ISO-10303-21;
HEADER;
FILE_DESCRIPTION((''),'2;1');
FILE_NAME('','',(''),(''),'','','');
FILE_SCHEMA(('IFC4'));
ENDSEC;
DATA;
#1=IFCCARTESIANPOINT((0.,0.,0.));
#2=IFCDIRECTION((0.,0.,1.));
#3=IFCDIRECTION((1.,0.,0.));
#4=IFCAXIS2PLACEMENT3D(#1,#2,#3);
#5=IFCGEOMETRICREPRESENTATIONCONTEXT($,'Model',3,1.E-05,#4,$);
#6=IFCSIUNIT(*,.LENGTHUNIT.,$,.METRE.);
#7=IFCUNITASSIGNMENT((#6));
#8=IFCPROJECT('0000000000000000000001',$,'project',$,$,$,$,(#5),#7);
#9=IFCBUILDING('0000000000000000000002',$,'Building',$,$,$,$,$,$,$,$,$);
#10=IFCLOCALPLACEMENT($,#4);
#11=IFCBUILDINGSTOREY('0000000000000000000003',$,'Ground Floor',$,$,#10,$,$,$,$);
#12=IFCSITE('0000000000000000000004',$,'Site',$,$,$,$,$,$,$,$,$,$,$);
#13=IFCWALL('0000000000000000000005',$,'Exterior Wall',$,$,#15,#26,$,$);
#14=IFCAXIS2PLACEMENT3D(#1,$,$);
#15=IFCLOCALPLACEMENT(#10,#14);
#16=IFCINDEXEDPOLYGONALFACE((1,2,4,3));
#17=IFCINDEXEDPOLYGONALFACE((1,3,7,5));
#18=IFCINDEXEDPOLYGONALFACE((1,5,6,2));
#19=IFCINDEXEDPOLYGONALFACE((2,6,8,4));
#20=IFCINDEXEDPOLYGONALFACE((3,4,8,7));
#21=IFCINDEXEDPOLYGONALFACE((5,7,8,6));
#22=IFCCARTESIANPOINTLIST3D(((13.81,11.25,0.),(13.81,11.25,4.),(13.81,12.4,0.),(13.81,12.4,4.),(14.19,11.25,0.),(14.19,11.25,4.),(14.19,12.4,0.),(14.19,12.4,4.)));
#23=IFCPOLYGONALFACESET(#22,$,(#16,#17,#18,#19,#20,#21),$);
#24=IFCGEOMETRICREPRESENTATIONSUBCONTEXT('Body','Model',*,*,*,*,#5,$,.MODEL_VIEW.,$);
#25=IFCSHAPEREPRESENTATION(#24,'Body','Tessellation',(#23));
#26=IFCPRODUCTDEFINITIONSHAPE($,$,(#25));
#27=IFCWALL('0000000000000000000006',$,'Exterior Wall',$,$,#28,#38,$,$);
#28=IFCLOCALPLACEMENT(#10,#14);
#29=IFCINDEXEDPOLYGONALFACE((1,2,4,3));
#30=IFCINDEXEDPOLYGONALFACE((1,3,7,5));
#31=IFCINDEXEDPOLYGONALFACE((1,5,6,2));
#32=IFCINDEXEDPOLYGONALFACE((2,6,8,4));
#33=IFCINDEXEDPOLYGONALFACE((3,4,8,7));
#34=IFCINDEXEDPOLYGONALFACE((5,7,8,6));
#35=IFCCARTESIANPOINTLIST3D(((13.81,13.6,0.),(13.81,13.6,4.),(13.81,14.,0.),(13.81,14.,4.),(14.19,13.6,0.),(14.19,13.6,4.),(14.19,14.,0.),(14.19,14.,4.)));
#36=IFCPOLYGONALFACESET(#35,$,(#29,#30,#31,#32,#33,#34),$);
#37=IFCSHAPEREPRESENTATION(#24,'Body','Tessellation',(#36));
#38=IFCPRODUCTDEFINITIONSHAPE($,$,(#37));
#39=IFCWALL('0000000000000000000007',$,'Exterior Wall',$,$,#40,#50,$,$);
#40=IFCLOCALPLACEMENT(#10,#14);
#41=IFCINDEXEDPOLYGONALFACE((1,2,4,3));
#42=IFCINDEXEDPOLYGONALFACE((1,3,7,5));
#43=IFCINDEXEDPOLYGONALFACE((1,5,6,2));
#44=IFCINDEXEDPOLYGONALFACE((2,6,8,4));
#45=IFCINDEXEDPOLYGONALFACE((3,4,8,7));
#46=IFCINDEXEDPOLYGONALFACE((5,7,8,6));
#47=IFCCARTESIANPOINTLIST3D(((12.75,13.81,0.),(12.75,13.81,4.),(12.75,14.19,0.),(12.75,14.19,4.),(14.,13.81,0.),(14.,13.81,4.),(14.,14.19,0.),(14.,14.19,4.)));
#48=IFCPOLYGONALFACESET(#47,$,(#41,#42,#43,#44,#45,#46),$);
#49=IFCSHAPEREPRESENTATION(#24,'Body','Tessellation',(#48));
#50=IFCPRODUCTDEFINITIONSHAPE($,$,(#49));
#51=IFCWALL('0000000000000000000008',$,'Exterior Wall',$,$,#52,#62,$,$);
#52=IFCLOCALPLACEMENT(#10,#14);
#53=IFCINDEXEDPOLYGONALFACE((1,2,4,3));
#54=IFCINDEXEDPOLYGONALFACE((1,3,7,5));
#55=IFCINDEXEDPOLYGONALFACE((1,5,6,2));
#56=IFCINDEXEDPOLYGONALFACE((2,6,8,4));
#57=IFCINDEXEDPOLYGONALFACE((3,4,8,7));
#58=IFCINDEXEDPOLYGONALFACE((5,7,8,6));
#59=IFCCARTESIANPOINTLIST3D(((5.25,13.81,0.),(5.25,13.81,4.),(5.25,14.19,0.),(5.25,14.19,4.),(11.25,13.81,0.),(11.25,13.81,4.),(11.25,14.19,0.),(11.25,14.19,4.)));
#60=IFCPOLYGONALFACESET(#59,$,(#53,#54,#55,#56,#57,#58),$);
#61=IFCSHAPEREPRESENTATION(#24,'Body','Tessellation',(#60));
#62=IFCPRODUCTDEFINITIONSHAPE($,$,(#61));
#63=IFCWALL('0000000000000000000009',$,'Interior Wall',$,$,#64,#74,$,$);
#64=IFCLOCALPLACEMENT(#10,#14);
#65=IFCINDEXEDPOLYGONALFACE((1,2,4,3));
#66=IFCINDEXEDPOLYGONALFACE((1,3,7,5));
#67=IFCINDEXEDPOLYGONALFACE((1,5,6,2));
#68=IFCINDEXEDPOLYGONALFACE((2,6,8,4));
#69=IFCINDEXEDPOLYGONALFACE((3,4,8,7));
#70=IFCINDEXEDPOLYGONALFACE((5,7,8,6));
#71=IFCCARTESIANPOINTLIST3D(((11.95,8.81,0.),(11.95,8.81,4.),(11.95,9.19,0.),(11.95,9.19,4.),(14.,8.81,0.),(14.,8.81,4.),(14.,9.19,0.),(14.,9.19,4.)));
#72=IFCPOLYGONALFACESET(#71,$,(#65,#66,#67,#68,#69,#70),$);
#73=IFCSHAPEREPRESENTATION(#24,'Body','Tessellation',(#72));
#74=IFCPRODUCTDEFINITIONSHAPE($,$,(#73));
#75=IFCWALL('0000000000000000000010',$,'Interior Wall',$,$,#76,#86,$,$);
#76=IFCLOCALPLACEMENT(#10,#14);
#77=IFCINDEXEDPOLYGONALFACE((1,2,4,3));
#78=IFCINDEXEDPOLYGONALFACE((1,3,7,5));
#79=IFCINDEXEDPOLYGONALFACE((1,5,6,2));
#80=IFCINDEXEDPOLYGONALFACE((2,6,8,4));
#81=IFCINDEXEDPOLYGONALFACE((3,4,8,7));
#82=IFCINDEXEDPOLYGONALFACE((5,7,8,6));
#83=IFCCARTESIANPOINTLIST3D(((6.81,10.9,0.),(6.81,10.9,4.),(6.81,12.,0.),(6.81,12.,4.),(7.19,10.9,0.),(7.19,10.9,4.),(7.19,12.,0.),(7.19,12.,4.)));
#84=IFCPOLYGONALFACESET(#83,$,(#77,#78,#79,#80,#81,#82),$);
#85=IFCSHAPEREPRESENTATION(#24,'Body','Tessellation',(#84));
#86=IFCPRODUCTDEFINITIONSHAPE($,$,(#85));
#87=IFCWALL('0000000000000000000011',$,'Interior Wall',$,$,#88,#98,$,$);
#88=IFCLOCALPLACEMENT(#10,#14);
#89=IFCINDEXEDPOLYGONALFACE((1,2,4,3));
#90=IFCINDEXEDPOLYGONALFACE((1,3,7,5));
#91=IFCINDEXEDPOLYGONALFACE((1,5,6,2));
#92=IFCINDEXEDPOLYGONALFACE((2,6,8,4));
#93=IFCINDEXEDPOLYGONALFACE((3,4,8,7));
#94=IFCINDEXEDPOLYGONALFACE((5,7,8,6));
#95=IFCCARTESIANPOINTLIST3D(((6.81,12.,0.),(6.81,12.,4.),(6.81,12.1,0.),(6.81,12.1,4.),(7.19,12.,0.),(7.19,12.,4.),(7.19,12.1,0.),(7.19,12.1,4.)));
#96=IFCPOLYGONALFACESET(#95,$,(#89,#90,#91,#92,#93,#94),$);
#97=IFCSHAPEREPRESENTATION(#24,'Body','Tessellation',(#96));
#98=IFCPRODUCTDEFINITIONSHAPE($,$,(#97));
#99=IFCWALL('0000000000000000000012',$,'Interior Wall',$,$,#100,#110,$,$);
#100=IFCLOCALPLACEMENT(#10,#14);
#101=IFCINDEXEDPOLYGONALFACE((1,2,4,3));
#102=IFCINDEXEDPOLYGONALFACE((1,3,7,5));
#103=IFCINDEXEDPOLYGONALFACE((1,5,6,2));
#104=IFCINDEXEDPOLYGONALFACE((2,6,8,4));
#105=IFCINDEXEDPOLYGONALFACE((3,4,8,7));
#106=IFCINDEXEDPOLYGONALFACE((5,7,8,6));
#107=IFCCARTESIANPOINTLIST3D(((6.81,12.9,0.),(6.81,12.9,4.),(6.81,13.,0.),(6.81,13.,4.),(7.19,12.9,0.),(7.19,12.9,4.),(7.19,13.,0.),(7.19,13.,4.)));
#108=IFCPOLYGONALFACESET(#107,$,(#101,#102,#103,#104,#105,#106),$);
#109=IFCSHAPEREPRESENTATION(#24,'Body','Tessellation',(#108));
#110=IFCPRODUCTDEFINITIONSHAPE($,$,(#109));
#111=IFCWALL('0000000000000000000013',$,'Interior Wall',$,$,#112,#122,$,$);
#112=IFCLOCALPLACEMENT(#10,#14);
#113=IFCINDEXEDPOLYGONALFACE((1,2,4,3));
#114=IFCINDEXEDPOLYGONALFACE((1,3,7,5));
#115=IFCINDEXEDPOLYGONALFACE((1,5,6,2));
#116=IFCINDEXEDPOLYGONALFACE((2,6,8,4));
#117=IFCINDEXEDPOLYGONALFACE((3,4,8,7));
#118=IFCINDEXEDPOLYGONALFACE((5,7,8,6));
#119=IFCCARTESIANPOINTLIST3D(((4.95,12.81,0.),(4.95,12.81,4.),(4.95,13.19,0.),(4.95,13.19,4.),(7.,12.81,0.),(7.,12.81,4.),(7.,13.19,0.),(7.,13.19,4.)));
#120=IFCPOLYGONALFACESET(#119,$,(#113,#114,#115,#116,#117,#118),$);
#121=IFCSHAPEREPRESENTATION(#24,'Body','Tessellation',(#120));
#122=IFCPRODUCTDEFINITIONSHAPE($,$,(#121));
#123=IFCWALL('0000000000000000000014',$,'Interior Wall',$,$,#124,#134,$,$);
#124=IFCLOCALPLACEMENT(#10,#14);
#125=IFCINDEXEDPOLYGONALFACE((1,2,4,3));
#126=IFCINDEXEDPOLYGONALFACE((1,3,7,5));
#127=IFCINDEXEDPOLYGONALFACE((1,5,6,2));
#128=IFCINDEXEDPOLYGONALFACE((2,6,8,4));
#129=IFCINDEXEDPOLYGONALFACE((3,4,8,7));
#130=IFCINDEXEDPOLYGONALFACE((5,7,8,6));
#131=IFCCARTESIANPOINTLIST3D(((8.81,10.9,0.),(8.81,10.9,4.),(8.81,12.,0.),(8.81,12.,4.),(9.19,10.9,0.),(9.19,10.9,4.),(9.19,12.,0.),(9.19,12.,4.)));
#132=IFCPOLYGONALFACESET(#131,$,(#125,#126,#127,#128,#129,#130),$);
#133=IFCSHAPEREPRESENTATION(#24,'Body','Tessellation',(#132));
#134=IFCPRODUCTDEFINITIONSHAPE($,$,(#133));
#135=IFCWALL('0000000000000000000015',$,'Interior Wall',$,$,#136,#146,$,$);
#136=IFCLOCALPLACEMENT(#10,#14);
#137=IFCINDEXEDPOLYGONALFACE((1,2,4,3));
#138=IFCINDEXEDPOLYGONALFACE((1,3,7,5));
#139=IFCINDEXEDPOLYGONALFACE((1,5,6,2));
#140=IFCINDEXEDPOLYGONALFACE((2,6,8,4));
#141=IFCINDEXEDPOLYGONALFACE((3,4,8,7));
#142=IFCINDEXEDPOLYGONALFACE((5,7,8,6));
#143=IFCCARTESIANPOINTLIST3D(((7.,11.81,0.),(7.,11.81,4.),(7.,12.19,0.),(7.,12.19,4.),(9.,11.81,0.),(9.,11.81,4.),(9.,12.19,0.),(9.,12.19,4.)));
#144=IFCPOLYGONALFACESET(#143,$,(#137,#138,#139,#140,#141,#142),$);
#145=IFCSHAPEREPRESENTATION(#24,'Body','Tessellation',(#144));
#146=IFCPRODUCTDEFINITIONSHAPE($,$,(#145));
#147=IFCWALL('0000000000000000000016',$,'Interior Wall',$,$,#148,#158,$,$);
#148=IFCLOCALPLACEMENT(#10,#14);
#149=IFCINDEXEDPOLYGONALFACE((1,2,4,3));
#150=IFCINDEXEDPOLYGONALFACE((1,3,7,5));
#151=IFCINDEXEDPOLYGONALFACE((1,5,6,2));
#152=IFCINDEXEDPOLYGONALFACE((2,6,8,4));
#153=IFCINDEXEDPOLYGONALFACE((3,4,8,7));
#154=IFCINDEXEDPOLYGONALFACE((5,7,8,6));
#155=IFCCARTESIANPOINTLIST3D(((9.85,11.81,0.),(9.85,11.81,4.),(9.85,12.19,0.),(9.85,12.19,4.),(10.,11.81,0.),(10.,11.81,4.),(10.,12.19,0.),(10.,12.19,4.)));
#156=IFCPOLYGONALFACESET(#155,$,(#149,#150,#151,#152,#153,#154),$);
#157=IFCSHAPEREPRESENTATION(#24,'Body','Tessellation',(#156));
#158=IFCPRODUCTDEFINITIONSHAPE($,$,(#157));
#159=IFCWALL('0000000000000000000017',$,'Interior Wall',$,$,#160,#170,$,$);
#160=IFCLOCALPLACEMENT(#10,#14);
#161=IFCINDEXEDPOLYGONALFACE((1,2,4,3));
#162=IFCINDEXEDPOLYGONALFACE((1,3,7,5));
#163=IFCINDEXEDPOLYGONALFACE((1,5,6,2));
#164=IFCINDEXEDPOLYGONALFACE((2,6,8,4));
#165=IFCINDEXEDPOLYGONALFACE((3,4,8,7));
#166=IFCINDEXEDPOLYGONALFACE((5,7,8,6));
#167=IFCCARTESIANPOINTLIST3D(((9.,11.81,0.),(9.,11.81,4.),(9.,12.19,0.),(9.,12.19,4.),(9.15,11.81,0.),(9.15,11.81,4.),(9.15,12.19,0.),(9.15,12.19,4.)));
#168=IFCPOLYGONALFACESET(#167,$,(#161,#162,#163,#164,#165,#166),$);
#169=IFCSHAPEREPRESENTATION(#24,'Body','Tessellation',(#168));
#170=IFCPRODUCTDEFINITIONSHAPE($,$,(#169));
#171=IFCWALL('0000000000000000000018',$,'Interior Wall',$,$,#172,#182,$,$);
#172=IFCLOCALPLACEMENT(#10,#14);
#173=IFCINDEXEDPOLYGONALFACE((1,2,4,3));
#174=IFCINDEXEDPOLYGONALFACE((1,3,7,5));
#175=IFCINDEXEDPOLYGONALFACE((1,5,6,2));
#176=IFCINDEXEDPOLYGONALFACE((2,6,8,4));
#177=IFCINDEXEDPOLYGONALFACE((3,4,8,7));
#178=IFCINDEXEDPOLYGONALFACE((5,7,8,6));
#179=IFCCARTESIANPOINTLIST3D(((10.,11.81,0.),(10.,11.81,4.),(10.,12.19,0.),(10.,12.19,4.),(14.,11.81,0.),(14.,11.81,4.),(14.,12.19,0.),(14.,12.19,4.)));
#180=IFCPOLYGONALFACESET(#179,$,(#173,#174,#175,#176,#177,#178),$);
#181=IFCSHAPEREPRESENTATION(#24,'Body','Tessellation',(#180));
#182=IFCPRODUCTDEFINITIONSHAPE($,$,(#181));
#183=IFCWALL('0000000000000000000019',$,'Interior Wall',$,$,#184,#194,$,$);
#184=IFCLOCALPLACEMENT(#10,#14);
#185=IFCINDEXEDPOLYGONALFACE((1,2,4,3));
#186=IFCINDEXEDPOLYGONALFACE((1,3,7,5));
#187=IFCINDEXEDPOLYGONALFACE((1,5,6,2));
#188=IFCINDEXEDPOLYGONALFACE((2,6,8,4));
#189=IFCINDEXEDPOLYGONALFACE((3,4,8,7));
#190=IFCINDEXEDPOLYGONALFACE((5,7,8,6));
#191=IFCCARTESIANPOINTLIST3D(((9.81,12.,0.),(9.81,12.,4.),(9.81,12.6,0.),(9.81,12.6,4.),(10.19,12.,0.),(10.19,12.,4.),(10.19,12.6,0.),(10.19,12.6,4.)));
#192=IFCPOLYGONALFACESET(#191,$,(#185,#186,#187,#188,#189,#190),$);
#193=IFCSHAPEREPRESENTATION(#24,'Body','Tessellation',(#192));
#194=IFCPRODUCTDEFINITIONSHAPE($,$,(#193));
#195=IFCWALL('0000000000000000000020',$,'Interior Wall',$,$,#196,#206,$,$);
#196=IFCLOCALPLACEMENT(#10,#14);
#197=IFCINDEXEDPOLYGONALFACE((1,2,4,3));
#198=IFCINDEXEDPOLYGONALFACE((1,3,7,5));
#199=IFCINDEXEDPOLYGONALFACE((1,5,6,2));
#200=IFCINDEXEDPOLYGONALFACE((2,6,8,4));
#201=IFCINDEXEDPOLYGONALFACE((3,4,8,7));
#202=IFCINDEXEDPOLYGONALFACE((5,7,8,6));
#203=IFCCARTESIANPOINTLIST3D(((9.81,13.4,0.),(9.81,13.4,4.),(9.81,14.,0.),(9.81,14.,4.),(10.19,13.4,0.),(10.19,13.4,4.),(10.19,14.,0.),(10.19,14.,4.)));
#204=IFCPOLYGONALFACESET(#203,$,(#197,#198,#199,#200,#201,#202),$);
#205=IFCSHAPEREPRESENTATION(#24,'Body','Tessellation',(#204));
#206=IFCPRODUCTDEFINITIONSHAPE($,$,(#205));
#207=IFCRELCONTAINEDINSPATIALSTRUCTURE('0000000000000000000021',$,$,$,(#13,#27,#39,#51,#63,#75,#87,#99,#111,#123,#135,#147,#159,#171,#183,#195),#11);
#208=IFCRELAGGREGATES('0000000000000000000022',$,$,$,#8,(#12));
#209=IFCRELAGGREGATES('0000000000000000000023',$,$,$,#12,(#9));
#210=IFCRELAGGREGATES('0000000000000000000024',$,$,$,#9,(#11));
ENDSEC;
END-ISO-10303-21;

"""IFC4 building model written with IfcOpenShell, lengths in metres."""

from ifc_helpers import new_model, si_unit, frame, origin_with_axes, place, context, subcontext, project, spatial, indexed_curve, outline, extrude, element, save


model = new_model("IFC4")

# Units and contexts
model_context = context("Model", 3, precision=1e-05, world=origin_with_axes())
body_context = subcontext(model_context, "Body", "Model", "MODEL_VIEW")
ifc_project = project(units=[si_unit("LENGTHUNIT", "METRE")], contexts=[model_context])

# Site, building, storey
site = spatial("IfcSite", under=ifc_project, Name="Site")
building = spatial("IfcBuilding", under=site, Name="Building")
storey_placement = place(None, origin_with_axes())
storey = spatial("IfcBuildingStorey", under=building, at=storey_placement, Name="Ground Floor")

# Walls
wall_1_placement = place(storey_placement, frame((14.0, 11.25, 0.0), z_axis=(0.0, 0.0, 1.0), x_axis=(0.0, 1.0, 0.0)))
element("IfcWall", 1, at=wall_1_placement, inside=storey, Name="Exterior Wall", context=body_context, shape_type="SweptSolid", body=[
    extrude(outline(indexed_curve([(0.0, 0.0), (0.0, 0.38), (1.15, 0.38), (1.15, 0.0), (0.0, 0.0)], self_intersect=False)), frame((0.0, -0.19, 0.0), z_axis=(0.0, 0.0, 1.0), x_axis=(1.0, 0.0, 0.0)), (0.0, 0.0, 1.0), 4.0),
])
wall_2_placement = place(storey_placement, frame((14.0, 13.6, 0.0), z_axis=(0.0, 0.0, 1.0), x_axis=(0.0, 1.0, 0.0)))
element("IfcWall", 2, at=wall_2_placement, inside=storey, Name="Exterior Wall", context=body_context, shape_type="SweptSolid", body=[
    extrude(outline(indexed_curve([(0.0, 0.0), (0.0, 0.38), (0.4, 0.38), (0.4, 0.0), (0.0, 0.0)], self_intersect=False)), frame((0.0, -0.19, 0.0), z_axis=(0.0, 0.0, 1.0), x_axis=(1.0, 0.0, 0.0)), (0.0, 0.0, 1.0), 4.0),
])
wall_3_placement = place(storey_placement, frame((14.0, 14.0, 0.0), z_axis=(0.0, 0.0, 1.0), x_axis=(-1.0, 0.0, 0.0)))
element("IfcWall", 3, at=wall_3_placement, inside=storey, Name="Exterior Wall", context=body_context, shape_type="SweptSolid", body=[
    extrude(outline(indexed_curve([(0.0, 0.0), (0.0, 0.38), (1.25, 0.38), (1.25, 0.0), (0.0, 0.0)], self_intersect=False)), frame((0.0, -0.19, 0.0), z_axis=(0.0, 0.0, 1.0), x_axis=(1.0, 0.0, 0.0)), (0.0, 0.0, 1.0), 4.0),
])
wall_4_placement = place(storey_placement, frame((11.25, 14.0, 0.0), z_axis=(0.0, 0.0, 1.0), x_axis=(-1.0, 0.0, 0.0)))
element("IfcWall", 4, at=wall_4_placement, inside=storey, Name="Exterior Wall", context=body_context, shape_type="SweptSolid", body=[
    extrude(outline(indexed_curve([(0.0, 0.0), (0.0, 0.38), (6.0, 0.38), (6.0, 0.0), (0.0, 0.0)], self_intersect=False)), frame((0.0, -0.19, 0.0), z_axis=(0.0, 0.0, 1.0), x_axis=(1.0, 0.0, 0.0)), (0.0, 0.0, 1.0), 4.0),
])
wall_5_placement = place(storey_placement, frame((14.0, 9.0, 0.0), z_axis=(0.0, 0.0, 1.0), x_axis=(-1.0, 0.0, 0.0)))
element("IfcWall", 5, at=wall_5_placement, inside=storey, Name="Interior Wall", context=body_context, shape_type="SweptSolid", body=[
    extrude(outline(indexed_curve([(0.0, 0.0), (0.0, 0.38), (2.05, 0.38), (2.05, 0.0), (0.0, 0.0)], self_intersect=False)), frame((0.0, -0.19, 0.0), z_axis=(0.0, 0.0, 1.0), x_axis=(1.0, 0.0, 0.0)), (0.0, 0.0, 1.0), 4.0),
])
wall_6_placement = place(storey_placement, frame((7.0, 10.9, 0.0), z_axis=(0.0, 0.0, 1.0), x_axis=(0.0, 1.0, 0.0)))
element("IfcWall", 6, at=wall_6_placement, inside=storey, Name="Interior Wall", context=body_context, shape_type="SweptSolid", body=[
    extrude(outline(indexed_curve([(0.0, 0.0), (0.0, 0.38), (1.1, 0.38), (1.1, 0.0), (0.0, 0.0)], self_intersect=False)), frame((0.0, -0.19, 0.0), z_axis=(0.0, 0.0, 1.0), x_axis=(1.0, 0.0, 0.0)), (0.0, 0.0, 1.0), 4.0),
])
for number, where, z_axis, x_axis, name in (
    (7, (7.0, 12.0, 0.0), (0.0, 0.0, 1.0), (0.0, 1.0, 0.0), "Interior Wall"),
    (8, (7.0, 12.9, 0.0), (0.0, 0.0, 1.0), (0.0, 1.0, 0.0), "Interior Wall"),
):
    element("IfcWall", number, at=place(storey_placement, frame(where, z_axis=z_axis, x_axis=x_axis)), inside=storey, Name=name, context=body_context, shape_type="SweptSolid", body=[
        extrude(outline(indexed_curve([(0.0, 0.0), (0.0, 0.38), (0.1, 0.38), (0.1, 0.0), (0.0, 0.0)], self_intersect=False)), frame((0.0, -0.19, 0.0), z_axis=(0.0, 0.0, 1.0), x_axis=(1.0, 0.0, 0.0)), (0.0, 0.0, 1.0), 4.0),
    ])
wall_7_placement = place(storey_placement, frame((7.0, 13.0, 0.0), z_axis=(0.0, 0.0, 1.0), x_axis=(-1.0, 0.0, 0.0)))
element("IfcWall", 9, at=wall_7_placement, inside=storey, Name="Interior Wall", context=body_context, shape_type="SweptSolid", body=[
    extrude(outline(indexed_curve([(0.0, 0.0), (0.0, 0.38), (2.05, 0.38), (2.05, 0.0), (0.0, 0.0)], self_intersect=False)), frame((0.0, -0.19, 0.0), z_axis=(0.0, 0.0, 1.0), x_axis=(1.0, 0.0, 0.0)), (0.0, 0.0, 1.0), 4.0),
])
wall_8_placement = place(storey_placement, frame((9.0, 10.9, 0.0), z_axis=(0.0, 0.0, 1.0), x_axis=(0.0, 1.0, 0.0)))
element("IfcWall", 10, at=wall_8_placement, inside=storey, Name="Interior Wall", context=body_context, shape_type="SweptSolid", body=[
    extrude(outline(indexed_curve([(0.0, 0.0), (0.0, 0.38), (1.1, 0.38), (1.1, 0.0), (0.0, 0.0)], self_intersect=False)), frame((0.0, -0.19, 0.0), z_axis=(0.0, 0.0, 1.0), x_axis=(1.0, 0.0, 0.0)), (0.0, 0.0, 1.0), 4.0),
])
wall_9_placement = place(storey_placement, frame((9.0, 12.0, 0.0), z_axis=(0.0, 0.0, 1.0), x_axis=(-1.0, 0.0, 0.0)))
element("IfcWall", 11, at=wall_9_placement, inside=storey, Name="Interior Wall", context=body_context, shape_type="SweptSolid", body=[
    extrude(outline(indexed_curve([(0.0, 0.0), (0.0, 0.38), (2.0, 0.38), (2.0, 0.0), (0.0, 0.0)], self_intersect=False)), frame((0.0, -0.19, 0.0), z_axis=(0.0, 0.0, 1.0), x_axis=(1.0, 0.0, 0.0)), (0.0, 0.0, 1.0), 4.0),
])
for number, where, z_axis, x_axis, name in (
    (12, (10.0, 12.0, 0.0), (0.0, 0.0, 1.0), (-1.0, 0.0, 0.0), "Interior Wall"),
    (13, (9.15, 12.0, 0.0), (0.0, 0.0, 1.0), (-1.0, 0.0, 0.0), "Interior Wall"),
):
    element("IfcWall", number, at=place(storey_placement, frame(where, z_axis=z_axis, x_axis=x_axis)), inside=storey, Name=name, context=body_context, shape_type="SweptSolid", body=[
        extrude(outline(indexed_curve([(0.0, 0.0), (0.0, 0.38), (0.15, 0.38), (0.15, 0.0), (0.0, 0.0)], self_intersect=False)), frame((0.0, -0.19, 0.0), z_axis=(0.0, 0.0, 1.0), x_axis=(1.0, 0.0, 0.0)), (0.0, 0.0, 1.0), 4.0),
    ])
wall_10_placement = place(storey_placement, frame((14.0, 12.0, 0.0), z_axis=(0.0, 0.0, 1.0), x_axis=(-1.0, 0.0, 0.0)))
element("IfcWall", 14, at=wall_10_placement, inside=storey, Name="Interior Wall", context=body_context, shape_type="SweptSolid", body=[
    extrude(outline(indexed_curve([(0.0, 0.0), (0.0, 0.38), (4.0, 0.38), (4.0, 0.0), (0.0, 0.0)], self_intersect=False)), frame((0.0, -0.19, 0.0), z_axis=(0.0, 0.0, 1.0), x_axis=(1.0, 0.0, 0.0)), (0.0, 0.0, 1.0), 4.0),
])
for number, where, z_axis, x_axis, name in (
    (15, (10.0, 12.0, 0.0), (0.0, 0.0, 1.0), (0.0, 1.0, 0.0), "Interior Wall"),
    (16, (10.0, 13.4, 0.0), (0.0, 0.0, 1.0), (0.0, 1.0, 0.0), "Interior Wall"),
):
    element("IfcWall", number, at=place(storey_placement, frame(where, z_axis=z_axis, x_axis=x_axis)), inside=storey, Name=name, context=body_context, shape_type="SweptSolid", body=[
        extrude(outline(indexed_curve([(0.0, 0.0), (0.0, 0.38), (0.6, 0.38), (0.6, 0.0), (0.0, 0.0)], self_intersect=False)), frame((0.0, -0.19, 0.0), z_axis=(0.0, 0.0, 1.0), x_axis=(1.0, 0.0, 0.0)), (0.0, 0.0, 1.0), 4.0),
    ])

save(model, "model.ifc")
